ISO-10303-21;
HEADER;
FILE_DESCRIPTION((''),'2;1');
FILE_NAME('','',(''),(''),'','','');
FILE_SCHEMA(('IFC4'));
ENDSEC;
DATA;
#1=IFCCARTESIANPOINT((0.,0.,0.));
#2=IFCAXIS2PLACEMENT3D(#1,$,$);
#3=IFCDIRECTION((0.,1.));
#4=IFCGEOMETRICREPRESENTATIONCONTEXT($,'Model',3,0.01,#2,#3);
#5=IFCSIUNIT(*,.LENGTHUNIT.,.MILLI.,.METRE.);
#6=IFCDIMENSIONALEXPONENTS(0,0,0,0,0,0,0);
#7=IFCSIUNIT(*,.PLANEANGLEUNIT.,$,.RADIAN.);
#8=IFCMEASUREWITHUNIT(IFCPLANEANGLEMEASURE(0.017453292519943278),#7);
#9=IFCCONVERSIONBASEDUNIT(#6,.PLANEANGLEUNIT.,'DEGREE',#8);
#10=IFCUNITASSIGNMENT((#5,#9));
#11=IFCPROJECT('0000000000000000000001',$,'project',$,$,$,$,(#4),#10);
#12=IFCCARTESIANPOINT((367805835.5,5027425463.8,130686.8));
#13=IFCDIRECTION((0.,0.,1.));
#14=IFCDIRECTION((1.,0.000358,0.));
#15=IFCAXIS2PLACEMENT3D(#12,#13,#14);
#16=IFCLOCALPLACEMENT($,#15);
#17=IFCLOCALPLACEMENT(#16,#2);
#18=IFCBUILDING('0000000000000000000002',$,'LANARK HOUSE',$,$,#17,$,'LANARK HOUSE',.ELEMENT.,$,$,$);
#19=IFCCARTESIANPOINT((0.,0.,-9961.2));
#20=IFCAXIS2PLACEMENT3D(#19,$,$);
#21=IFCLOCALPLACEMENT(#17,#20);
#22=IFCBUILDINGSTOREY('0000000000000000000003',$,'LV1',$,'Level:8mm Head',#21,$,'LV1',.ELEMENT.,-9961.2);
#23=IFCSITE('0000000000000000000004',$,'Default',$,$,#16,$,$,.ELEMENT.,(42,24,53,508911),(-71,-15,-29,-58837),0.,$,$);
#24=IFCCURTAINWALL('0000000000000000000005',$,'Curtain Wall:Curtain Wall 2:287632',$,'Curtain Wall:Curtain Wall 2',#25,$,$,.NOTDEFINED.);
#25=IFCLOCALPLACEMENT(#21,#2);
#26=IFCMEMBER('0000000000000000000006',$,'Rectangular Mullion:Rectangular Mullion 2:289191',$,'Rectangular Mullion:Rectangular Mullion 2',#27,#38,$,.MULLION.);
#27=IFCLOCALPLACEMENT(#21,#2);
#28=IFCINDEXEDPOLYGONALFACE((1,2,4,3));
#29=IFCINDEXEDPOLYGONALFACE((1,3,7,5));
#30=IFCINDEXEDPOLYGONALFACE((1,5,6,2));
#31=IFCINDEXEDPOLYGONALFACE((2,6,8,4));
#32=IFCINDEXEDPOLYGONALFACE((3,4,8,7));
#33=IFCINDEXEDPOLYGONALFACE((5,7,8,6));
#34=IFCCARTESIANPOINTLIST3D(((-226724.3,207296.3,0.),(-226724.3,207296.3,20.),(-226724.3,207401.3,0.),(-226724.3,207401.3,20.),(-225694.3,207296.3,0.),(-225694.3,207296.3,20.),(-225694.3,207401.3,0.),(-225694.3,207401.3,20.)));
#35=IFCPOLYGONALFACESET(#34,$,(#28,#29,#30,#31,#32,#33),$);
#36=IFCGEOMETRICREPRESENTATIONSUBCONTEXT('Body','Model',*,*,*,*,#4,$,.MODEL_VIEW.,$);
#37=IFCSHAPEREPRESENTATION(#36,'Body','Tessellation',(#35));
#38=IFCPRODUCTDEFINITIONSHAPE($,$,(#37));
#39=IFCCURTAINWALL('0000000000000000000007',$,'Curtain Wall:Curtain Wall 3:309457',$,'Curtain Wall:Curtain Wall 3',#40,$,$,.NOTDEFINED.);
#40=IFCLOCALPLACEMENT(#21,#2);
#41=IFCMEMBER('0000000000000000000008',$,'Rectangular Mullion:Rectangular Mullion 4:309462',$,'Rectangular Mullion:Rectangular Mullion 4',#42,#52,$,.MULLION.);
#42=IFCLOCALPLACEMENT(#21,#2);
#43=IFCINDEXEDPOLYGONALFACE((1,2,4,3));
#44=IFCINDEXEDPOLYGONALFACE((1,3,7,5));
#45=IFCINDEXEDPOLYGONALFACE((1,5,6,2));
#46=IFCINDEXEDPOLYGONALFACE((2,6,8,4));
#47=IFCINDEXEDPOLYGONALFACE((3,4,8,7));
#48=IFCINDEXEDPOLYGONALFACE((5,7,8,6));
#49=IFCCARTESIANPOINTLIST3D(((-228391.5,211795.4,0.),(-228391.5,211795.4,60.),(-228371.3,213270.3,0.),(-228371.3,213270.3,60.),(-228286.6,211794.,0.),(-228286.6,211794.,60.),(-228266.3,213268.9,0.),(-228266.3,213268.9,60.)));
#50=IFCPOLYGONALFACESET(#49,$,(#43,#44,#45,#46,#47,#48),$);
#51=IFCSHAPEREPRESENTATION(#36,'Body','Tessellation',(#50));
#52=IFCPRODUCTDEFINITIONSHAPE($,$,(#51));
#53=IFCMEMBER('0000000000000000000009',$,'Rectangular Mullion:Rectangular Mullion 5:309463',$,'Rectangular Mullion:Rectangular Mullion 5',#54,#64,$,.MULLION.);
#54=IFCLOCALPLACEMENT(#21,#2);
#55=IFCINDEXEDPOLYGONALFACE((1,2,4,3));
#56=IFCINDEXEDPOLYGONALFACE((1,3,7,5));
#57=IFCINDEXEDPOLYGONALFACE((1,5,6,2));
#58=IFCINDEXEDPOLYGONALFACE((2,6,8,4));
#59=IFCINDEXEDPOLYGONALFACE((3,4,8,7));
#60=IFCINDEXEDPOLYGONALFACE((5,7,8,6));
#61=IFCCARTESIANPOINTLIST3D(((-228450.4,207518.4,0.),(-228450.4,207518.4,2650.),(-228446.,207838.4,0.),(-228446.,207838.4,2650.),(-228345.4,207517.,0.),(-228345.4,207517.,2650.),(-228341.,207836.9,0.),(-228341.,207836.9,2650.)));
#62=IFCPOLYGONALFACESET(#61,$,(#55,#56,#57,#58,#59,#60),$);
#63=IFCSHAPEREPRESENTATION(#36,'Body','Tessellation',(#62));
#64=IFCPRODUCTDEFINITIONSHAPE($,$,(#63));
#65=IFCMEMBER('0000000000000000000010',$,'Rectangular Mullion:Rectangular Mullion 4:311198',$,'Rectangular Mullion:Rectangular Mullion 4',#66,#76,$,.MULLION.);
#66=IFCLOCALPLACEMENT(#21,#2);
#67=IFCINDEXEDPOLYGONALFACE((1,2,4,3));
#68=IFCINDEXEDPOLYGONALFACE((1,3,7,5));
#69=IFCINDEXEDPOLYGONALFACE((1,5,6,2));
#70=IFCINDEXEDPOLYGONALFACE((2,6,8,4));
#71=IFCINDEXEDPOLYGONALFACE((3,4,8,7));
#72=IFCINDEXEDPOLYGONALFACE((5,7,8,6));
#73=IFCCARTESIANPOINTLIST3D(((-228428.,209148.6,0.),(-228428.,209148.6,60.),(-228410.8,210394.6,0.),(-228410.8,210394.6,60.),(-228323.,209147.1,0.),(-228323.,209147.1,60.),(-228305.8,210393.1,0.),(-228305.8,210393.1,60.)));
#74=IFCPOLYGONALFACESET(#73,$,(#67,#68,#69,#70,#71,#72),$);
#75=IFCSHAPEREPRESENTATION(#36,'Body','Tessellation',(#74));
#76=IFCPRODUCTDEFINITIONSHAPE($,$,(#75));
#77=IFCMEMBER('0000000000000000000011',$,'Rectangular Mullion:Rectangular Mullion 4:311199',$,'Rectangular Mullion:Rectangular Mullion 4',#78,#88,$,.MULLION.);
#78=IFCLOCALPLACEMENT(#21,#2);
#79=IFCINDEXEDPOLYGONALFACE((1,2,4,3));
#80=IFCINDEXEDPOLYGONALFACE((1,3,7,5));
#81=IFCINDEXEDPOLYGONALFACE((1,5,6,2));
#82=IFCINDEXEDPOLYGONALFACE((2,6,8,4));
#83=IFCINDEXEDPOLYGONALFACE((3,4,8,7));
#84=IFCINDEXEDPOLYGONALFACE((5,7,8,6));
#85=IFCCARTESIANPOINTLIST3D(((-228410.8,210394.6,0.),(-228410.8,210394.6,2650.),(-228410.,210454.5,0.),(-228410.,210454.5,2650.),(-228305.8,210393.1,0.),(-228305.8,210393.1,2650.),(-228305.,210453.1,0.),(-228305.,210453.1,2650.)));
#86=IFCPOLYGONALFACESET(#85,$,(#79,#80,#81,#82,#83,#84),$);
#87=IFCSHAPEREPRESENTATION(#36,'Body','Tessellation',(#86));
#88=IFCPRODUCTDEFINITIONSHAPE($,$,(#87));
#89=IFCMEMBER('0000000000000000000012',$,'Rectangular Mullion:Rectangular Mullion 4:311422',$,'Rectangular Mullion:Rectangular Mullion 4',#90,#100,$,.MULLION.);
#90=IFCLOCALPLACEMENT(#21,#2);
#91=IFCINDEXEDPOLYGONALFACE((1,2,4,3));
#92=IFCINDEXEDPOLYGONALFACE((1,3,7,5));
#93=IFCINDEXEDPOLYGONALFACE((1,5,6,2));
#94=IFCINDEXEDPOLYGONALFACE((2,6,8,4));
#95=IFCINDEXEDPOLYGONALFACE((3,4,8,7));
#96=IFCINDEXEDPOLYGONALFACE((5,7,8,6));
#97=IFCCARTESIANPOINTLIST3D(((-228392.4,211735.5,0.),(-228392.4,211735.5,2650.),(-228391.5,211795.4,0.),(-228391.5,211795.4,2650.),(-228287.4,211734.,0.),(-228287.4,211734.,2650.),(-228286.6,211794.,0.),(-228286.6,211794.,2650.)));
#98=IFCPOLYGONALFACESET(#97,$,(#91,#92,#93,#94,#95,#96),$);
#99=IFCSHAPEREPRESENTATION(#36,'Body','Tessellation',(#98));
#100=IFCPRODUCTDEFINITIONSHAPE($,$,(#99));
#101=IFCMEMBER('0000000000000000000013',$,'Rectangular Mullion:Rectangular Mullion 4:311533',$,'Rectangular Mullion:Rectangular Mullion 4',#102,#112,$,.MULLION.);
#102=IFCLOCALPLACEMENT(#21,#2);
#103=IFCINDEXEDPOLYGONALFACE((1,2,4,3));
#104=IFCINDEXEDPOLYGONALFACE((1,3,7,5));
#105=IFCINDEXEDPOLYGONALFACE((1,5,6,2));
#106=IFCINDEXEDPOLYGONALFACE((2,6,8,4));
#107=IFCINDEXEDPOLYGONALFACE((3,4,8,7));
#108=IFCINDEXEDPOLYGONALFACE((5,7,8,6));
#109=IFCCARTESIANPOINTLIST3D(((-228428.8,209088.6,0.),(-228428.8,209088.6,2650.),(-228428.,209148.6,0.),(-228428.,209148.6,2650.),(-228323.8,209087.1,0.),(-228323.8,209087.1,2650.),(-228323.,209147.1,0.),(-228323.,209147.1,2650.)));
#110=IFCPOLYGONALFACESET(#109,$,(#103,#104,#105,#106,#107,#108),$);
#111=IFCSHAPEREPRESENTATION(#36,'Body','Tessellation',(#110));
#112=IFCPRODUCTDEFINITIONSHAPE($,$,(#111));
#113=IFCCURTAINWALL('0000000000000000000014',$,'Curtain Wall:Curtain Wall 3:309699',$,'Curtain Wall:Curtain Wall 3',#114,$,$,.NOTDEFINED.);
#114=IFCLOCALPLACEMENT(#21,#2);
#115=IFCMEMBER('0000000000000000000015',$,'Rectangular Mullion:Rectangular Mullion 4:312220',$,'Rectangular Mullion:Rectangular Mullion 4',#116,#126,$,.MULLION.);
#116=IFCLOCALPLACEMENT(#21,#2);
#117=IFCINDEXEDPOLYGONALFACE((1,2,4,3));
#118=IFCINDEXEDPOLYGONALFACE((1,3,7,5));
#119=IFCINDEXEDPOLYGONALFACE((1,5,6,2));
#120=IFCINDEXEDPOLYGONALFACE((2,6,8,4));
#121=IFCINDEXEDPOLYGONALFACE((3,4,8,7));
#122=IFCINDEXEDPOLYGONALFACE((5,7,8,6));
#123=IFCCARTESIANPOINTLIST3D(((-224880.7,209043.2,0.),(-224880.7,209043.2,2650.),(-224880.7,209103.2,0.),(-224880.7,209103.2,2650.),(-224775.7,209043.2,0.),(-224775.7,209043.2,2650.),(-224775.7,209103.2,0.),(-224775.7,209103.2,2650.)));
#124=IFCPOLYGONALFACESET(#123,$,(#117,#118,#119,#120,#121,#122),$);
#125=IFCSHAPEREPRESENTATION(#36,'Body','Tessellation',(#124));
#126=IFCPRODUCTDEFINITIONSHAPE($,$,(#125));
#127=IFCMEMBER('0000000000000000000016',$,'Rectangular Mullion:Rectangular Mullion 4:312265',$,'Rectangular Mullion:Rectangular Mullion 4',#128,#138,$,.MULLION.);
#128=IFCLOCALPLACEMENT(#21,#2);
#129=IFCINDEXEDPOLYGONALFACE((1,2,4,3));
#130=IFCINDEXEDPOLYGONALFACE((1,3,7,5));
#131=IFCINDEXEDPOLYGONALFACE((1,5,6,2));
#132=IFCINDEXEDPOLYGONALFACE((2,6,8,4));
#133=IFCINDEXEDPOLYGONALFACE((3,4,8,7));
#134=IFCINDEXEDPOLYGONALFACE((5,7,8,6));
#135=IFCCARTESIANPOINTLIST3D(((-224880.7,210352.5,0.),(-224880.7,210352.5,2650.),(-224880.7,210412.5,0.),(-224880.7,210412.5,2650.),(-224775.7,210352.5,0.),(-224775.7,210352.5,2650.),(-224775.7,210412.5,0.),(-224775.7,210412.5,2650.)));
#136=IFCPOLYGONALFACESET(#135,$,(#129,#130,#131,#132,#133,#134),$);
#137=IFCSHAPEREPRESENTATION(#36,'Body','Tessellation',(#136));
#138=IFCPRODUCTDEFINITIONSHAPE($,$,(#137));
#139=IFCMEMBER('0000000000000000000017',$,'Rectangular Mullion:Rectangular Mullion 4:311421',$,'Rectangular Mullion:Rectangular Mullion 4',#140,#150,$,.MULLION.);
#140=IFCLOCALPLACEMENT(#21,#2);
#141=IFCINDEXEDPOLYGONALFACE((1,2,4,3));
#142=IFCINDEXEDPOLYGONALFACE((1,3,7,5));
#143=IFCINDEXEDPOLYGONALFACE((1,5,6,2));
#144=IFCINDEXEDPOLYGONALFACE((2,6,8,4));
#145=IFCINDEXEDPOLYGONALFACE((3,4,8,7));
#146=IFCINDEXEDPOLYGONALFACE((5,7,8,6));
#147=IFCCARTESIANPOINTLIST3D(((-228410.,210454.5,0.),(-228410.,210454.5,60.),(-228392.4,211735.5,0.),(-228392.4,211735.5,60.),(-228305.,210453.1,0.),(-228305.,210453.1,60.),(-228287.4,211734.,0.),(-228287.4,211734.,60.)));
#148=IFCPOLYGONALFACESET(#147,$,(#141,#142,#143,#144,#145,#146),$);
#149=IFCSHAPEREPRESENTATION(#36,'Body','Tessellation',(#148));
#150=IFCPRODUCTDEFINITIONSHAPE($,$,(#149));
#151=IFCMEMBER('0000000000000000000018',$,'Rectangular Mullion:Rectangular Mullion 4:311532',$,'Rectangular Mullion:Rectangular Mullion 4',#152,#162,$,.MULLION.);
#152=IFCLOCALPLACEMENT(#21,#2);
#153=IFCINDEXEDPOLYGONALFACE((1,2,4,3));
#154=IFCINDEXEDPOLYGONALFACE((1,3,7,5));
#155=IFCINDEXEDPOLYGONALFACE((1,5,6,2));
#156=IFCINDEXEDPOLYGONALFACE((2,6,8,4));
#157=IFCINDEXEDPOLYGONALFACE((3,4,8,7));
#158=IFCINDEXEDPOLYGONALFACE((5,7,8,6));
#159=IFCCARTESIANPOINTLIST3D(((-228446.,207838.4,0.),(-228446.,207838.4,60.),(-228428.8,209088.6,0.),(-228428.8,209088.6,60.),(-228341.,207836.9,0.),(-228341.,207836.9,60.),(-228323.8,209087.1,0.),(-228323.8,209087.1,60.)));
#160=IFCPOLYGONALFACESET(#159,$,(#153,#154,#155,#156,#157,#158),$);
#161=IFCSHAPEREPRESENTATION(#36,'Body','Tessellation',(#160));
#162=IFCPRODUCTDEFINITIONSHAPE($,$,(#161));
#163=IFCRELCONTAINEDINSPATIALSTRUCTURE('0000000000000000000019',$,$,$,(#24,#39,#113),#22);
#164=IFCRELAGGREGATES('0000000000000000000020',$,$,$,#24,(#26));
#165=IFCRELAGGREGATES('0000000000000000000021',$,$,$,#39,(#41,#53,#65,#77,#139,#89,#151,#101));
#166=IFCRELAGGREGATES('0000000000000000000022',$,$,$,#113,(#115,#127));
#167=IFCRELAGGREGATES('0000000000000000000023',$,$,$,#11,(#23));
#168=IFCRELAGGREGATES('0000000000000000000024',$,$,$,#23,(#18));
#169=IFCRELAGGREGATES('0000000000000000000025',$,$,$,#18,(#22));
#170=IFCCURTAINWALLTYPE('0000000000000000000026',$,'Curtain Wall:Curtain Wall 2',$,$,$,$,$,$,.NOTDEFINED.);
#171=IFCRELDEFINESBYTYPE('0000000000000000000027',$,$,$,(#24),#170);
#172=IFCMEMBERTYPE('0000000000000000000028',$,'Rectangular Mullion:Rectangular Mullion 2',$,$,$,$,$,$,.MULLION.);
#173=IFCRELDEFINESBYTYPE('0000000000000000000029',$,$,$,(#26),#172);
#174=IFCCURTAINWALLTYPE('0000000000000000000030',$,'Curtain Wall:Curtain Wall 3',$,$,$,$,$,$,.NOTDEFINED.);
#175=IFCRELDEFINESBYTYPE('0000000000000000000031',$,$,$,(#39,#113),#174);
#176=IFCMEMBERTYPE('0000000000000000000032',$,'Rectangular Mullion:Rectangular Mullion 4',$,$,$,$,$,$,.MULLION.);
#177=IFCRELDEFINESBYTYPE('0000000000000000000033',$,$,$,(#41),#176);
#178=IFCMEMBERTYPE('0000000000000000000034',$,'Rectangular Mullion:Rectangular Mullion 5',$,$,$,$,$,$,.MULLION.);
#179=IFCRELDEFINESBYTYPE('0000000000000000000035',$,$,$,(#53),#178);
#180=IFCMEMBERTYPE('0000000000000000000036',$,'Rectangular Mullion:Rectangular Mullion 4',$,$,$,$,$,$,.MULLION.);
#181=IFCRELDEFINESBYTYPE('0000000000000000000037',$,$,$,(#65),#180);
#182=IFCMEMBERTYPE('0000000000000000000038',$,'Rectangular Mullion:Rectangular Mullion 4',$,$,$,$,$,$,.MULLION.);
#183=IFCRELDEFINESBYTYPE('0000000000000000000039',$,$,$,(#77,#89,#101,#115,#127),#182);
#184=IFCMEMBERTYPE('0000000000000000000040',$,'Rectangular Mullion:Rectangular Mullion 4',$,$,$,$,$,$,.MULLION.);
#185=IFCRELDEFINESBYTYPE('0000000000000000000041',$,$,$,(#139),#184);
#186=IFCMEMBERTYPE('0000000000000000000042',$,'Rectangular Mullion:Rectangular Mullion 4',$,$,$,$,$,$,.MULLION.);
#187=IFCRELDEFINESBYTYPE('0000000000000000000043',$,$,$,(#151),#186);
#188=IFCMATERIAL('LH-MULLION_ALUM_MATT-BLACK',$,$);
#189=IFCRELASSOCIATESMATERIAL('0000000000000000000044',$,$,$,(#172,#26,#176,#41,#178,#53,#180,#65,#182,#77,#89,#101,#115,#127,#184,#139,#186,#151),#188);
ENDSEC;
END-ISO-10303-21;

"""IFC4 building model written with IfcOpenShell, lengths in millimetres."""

from ifc_helpers import new_model, entity, si_unit, converted_unit, direction, frame, origin, place, context, subcontext, project, spatial, indexed_curve, outline, extrude, source, transform, mapped, material, type_object, type_shapes, element, aggregate, save


model = new_model("IFC4")

# Units and contexts
model_context = context("Model", 3, precision=0.01, world=origin(), true_north=direction((0.0, 1.0)))
body_context = subcontext(model_context, "Body", "Model", "MODEL_VIEW")
ifc_project = project(units=[si_unit("LENGTHUNIT", "METRE", prefix="MILLI"), converted_unit("PLANEANGLEUNIT", "DEGREE", entity("IfcPlaneAngleMeasure", 0.017453292519943278), si_unit("PLANEANGLEUNIT", "RADIAN"), dimensions=[0, 0, 0, 0, 0, 0, 0])], contexts=[model_context])

# Site, building, storey
site_placement = place(None, frame((367805835.5, 5027425463.8, 130686.8), z_axis=(0.0, 0.0, 1.0), x_axis=(1.0, 0.000358, 0.0)))
site = spatial("IfcSite", under=ifc_project, at=site_placement, Name="Default", CompositionType="ELEMENT", RefLatitude=(42, 24, 53, 508911), RefLongitude=(-71, -15, -29, -58837), RefElevation=0.0)
building_placement = place(site_placement, origin())
building = spatial("IfcBuilding", under=site, at=building_placement, Name="LANARK HOUSE", LongName="LANARK HOUSE", CompositionType="ELEMENT")
storey_placement = place(building_placement, frame((0.0, 0.0, -9961.2)))
storey = spatial("IfcBuildingStorey", under=building, at=storey_placement, Name="LV1", ObjectType="Level:8mm Head", LongName="LV1", CompositionType="ELEMENT", Elevation=-9961.2)

# Curtain wall
curtain_wall_type_1 = type_object("IfcCurtainWallType", Name="Curtain Wall:Curtain Wall 2", PredefinedType="NOTDEFINED")
curtain_wall_1_placement = place(storey_placement, frame((0.0, 0.0, 9961.2)))
curtain_wall_1 = element("IfcCurtainWall", 1, at=curtain_wall_1_placement, inside=storey, type_object=curtain_wall_type_1, Name="Curtain Wall:Curtain Wall 2:287632", ObjectType="Curtain Wall:Curtain Wall 2", PredefinedType="NOTDEFINED")
ifc_material_1 = material(Name="LH-MULLION_ALUM_MATT-BLACK")

# Member
member_type_1 = type_object("IfcMemberType", Name="Rectangular Mullion:Rectangular Mullion 2", PredefinedType="MULLION", material=ifc_material_1)
shared_shape_1 = source(origin(), body_context, "Body", "SweptSolid", [
    extrude(outline(indexed_curve([(-10.0, -52.5), (10.0, -52.5), (10.0, 52.5), (-10.0, 52.5), (-10.0, -52.5)], self_intersect=False)), frame((-10.0, -40.0, -1030.0), z_axis=(0.0, 0.0, 1.0), x_axis=(-1.0, 0.0, 0.0)), (0.0, 0.0, 1.0), 1030.0),
])
type_shapes(member_type_1, [shared_shape_1])
member_1_placement = place(curtain_wall_1_placement, frame((-225694.3, 207388.8, -9961.2), z_axis=(1.0, 0.0, 0.0), x_axis=(0.0, 0.0, -1.0)))
member_1 = element("IfcMember", 2, at=member_1_placement, type_object=member_type_1, material=ifc_material_1, Name="Rectangular Mullion:Rectangular Mullion 2:289191", ObjectType="Rectangular Mullion:Rectangular Mullion 2", PredefinedType="MULLION", context=body_context, shape_type="MappedRepresentation", body=[
    mapped(shared_shape_1, transform((0.0, 0.0, 0.0), scale=1.0)),
])
aggregate(curtain_wall_1, [member_1])

# Curtain walls, members
curtain_wall_type_2 = type_object("IfcCurtainWallType", Name="Curtain Wall:Curtain Wall 3", PredefinedType="NOTDEFINED")
curtain_wall_2_placement = place(storey_placement, frame((0.0, 0.0, 9961.2)))
curtain_wall_2 = element("IfcCurtainWall", 3, at=curtain_wall_2_placement, inside=storey, type_object=curtain_wall_type_2, Name="Curtain Wall:Curtain Wall 3:309457", ObjectType="Curtain Wall:Curtain Wall 3", PredefinedType="NOTDEFINED")
member_type_2 = type_object("IfcMemberType", Name="Rectangular Mullion:Rectangular Mullion 4", PredefinedType="MULLION", material=ifc_material_1)
shared_shape_2 = source(origin(), body_context, "Body", "SweptSolid", [
    extrude(outline(indexed_curve([(-30.0, -52.5), (30.0, -52.5), (30.0, 52.5), (-30.0, 52.5), (-30.0, -52.5)], self_intersect=False)), frame((-30.0, -40.0, -1475.0), z_axis=(0.0, 0.0, 1.0), x_axis=(-1.0, 0.0, 0.0)), (0.0, 0.0, 1.0), 1475.0),
])
type_shapes(member_type_2, [shared_shape_2])
member_2_placement = place(curtain_wall_2_placement, frame((-228358.8, 213270.1, -9961.2), z_axis=(0.013756, 0.999905, 0.0), x_axis=(0.0, 0.0, -1.0)))
member_2 = element("IfcMember", 4, at=member_2_placement, type_object=member_type_2, material=ifc_material_1, Name="Rectangular Mullion:Rectangular Mullion 4:309462", ObjectType="Rectangular Mullion:Rectangular Mullion 4", PredefinedType="MULLION", context=body_context, shape_type="MappedRepresentation", body=[
    mapped(shared_shape_2, transform((0.0, 0.0, 0.0), scale=1.0)),
])
member_type_3 = type_object("IfcMemberType", Name="Rectangular Mullion:Rectangular Mullion 5", PredefinedType="MULLION", material=ifc_material_1)
shared_shape_3 = source(origin(), body_context, "Body", "SweptSolid", [
    extrude(outline(indexed_curve([(-160.0, -52.5), (160.0, -52.5), (160.0, 52.5), (-160.0, 52.5), (-160.0, -52.5)], self_intersect=False)), frame((-160.0, -40.0, -2650.0), z_axis=(0.0, 0.0, 1.0), x_axis=(-1.0, 0.0, 0.0)), (0.0, 0.0, 1.0), 2650.0),
])
type_shapes(member_type_3, [shared_shape_3])
member_3_placement = place(curtain_wall_2_placement, frame((-228437.9, 207518.2, -9961.2), z_axis=(0.0, 0.0, -1.0), x_axis=(-0.013756, -0.999905, 0.0)))
member_3 = element("IfcMember", 5, at=member_3_placement, type_object=member_type_3, material=ifc_material_1, Name="Rectangular Mullion:Rectangular Mullion 5:309463", ObjectType="Rectangular Mullion:Rectangular Mullion 5", PredefinedType="MULLION", context=body_context, shape_type="MappedRepresentation", body=[
    mapped(shared_shape_3, transform((0.0, 0.0, 0.0), scale=1.0)),
])
member_type_4 = type_object("IfcMemberType", Name="Rectangular Mullion:Rectangular Mullion 4", PredefinedType="MULLION", material=ifc_material_1)
shared_shape_4 = source(origin(), body_context, "Body", "SweptSolid", [
    extrude(outline(indexed_curve([(-30.0, -52.5), (30.0, -52.5), (30.0, 52.5), (-30.0, 52.5), (-30.0, -52.5)], self_intersect=False)), frame((-30.0, -40.0, -1246.1), z_axis=(0.0, 0.0, 1.0), x_axis=(-1.0, 0.0, 0.0)), (0.0, 0.0, 1.0), 1246.1),
])
type_shapes(member_type_4, [shared_shape_4])
member_4_placement = place(curtain_wall_2_placement, frame((-228398.3, 210394.4, -9961.2), z_axis=(0.013756, 0.999905, 0.0), x_axis=(0.0, 0.0, -1.0)))
member_4 = element("IfcMember", 6, at=member_4_placement, type_object=member_type_4, material=ifc_material_1, Name="Rectangular Mullion:Rectangular Mullion 4:311198", ObjectType="Rectangular Mullion:Rectangular Mullion 4", PredefinedType="MULLION", context=body_context, shape_type="MappedRepresentation", body=[
    mapped(shared_shape_4, transform((0.0, 0.0, 0.0), scale=1.0)),
])
member_type_5 = type_object("IfcMemberType", Name="Rectangular Mullion:Rectangular Mullion 4", PredefinedType="MULLION", material=ifc_material_1)
shared_shape_5 = source(origin(), body_context, "Body", "SweptSolid", [
    extrude(outline(indexed_curve([(-30.0, -52.5), (30.0, -52.5), (30.0, 52.5), (-30.0, 52.5), (-30.0, -52.5)], self_intersect=False)), frame((0.0, -40.0, -2650.0), z_axis=(0.0, 0.0, 1.0), x_axis=(-1.0, 0.0, 0.0)), (0.0, 0.0, 1.0), 2650.0),
])
type_shapes(member_type_5, [shared_shape_5])
member_5_placement = place(curtain_wall_2_placement, frame((-228397.9, 210424.4, -9961.2), z_axis=(0.0, 0.0, -1.0), x_axis=(-0.013756, -0.999905, 0.0)))
member_5 = element("IfcMember", 7, at=member_5_placement, type_object=member_type_5, material=ifc_material_1, Name="Rectangular Mullion:Rectangular Mullion 4:311199", ObjectType="Rectangular Mullion:Rectangular Mullion 4", PredefinedType="MULLION", context=body_context, shape_type="MappedRepresentation", body=[
    mapped(shared_shape_5, transform((0.0, 0.0, 0.0), scale=1.0)),
])
member_6_placement = place(curtain_wall_2_placement, frame((-228379.5, 211765.3, -9961.2), z_axis=(0.0, 0.0, -1.0), x_axis=(-0.013756, -0.999905, 0.0)))
member_6 = element("IfcMember", 8, at=member_6_placement, type_object=member_type_5, material=ifc_material_1, Name="Rectangular Mullion:Rectangular Mullion 4:311422", ObjectType="Rectangular Mullion:Rectangular Mullion 4", PredefinedType="MULLION", context=body_context, shape_type="MappedRepresentation", body=[
    mapped(shared_shape_5, transform((0.0, 0.0, 0.0), scale=1.0)),
])
member_7_placement = place(curtain_wall_2_placement, frame((-228415.9, 209118.4, -9961.2), z_axis=(0.0, 0.0, -1.0), x_axis=(-0.013756, -0.999905, 0.0)))
member_7 = element("IfcMember", 9, at=member_7_placement, type_object=member_type_5, material=ifc_material_1, Name="Rectangular Mullion:Rectangular Mullion 4:311533", ObjectType="Rectangular Mullion:Rectangular Mullion 4", PredefinedType="MULLION", context=body_context, shape_type="MappedRepresentation", body=[
    mapped(shared_shape_5, transform((0.0, 0.0, 0.0), scale=1.0)),
])
curtain_wall_3_placement = place(storey_placement, frame((0.0, 0.0, 9961.2)))
curtain_wall_3 = element("IfcCurtainWall", 10, at=curtain_wall_3_placement, inside=storey, type_object=curtain_wall_type_2, Name="Curtain Wall:Curtain Wall 3:309699", ObjectType="Curtain Wall:Curtain Wall 3", PredefinedType="NOTDEFINED")
member_8_placement = place(curtain_wall_3_placement, frame((-224788.2, 209073.2, -9961.2), z_axis=(0.0, 0.0, -1.0), x_axis=(0.0, 1.0, 0.0)))
member_8 = element("IfcMember", 11, at=member_8_placement, type_object=member_type_5, material=ifc_material_1, Name="Rectangular Mullion:Rectangular Mullion 4:312220", ObjectType="Rectangular Mullion:Rectangular Mullion 4", PredefinedType="MULLION", context=body_context, shape_type="MappedRepresentation", body=[
    mapped(shared_shape_5, transform((0.0, 0.0, 0.0), scale=1.0)),
])
member_9_placement = place(curtain_wall_3_placement, frame((-224788.2, 210382.5, -9961.2), z_axis=(0.0, 0.0, -1.0), x_axis=(0.0, 1.0, 0.0)))
member_9 = element("IfcMember", 12, at=member_9_placement, type_object=member_type_5, material=ifc_material_1, Name="Rectangular Mullion:Rectangular Mullion 4:312265", ObjectType="Rectangular Mullion:Rectangular Mullion 4", PredefinedType="MULLION", context=body_context, shape_type="MappedRepresentation", body=[
    mapped(shared_shape_5, transform((0.0, 0.0, 0.0), scale=1.0)),
])

# Members
member_type_6 = type_object("IfcMemberType", Name="Rectangular Mullion:Rectangular Mullion 4", PredefinedType="MULLION", material=ifc_material_1)
shared_shape_6 = source(origin(), body_context, "Body", "SweptSolid", [
    extrude(outline(indexed_curve([(-30.0, -52.5), (30.0, -52.5), (30.0, 52.5), (-30.0, 52.5), (-30.0, -52.5)], self_intersect=False)), frame((-30.0, -40.0, -1281.0), z_axis=(0.0, 0.0, 1.0), x_axis=(-1.0, 0.0, 0.0)), (0.0, 0.0, 1.0), 1281.0),
])
type_shapes(member_type_6, [shared_shape_6])
member_10_placement = place(curtain_wall_2_placement, frame((-228379.9, 211735.3, -9961.2), z_axis=(0.013756, 0.999905, 0.0), x_axis=(0.0, 0.0, -1.0)))
member_10 = element("IfcMember", 13, at=member_10_placement, type_object=member_type_6, material=ifc_material_1, Name="Rectangular Mullion:Rectangular Mullion 4:311421", ObjectType="Rectangular Mullion:Rectangular Mullion 4", PredefinedType="MULLION", context=body_context, shape_type="MappedRepresentation", body=[
    mapped(shared_shape_6, transform((0.0, 0.0, 0.0), scale=1.0)),
])
member_type_7 = type_object("IfcMemberType", Name="Rectangular Mullion:Rectangular Mullion 4", PredefinedType="MULLION", material=ifc_material_1)
shared_shape_7 = source(origin(), body_context, "Body", "SweptSolid", [
    extrude(outline(indexed_curve([(-30.0, -52.5), (30.0, -52.5), (30.0, 52.5), (-30.0, 52.5), (-30.0, -52.5)], self_intersect=False)), frame((-30.0, -40.0, -1250.3), z_axis=(0.0, 0.0, 1.0), x_axis=(-1.0, 0.0, 0.0)), (0.0, 0.0, 1.0), 1250.3),
])
type_shapes(member_type_7, [shared_shape_7])
member_11_placement = place(curtain_wall_2_placement, frame((-228416.3, 209088.4, -9961.2), z_axis=(0.013756, 0.999905, 0.0), x_axis=(0.0, 0.0, -1.0)))
member_11 = element("IfcMember", 14, at=member_11_placement, type_object=member_type_7, material=ifc_material_1, Name="Rectangular Mullion:Rectangular Mullion 4:311532", ObjectType="Rectangular Mullion:Rectangular Mullion 4", PredefinedType="MULLION", context=body_context, shape_type="MappedRepresentation", body=[
    mapped(shared_shape_7, transform((0.0, 0.0, 0.0), scale=1.0)),
])
aggregate(curtain_wall_2, [member_2, member_3, member_4, member_5, member_10, member_6, member_11, member_7])
aggregate(curtain_wall_3, [member_8, member_9])

save(model, "model.ifc")
